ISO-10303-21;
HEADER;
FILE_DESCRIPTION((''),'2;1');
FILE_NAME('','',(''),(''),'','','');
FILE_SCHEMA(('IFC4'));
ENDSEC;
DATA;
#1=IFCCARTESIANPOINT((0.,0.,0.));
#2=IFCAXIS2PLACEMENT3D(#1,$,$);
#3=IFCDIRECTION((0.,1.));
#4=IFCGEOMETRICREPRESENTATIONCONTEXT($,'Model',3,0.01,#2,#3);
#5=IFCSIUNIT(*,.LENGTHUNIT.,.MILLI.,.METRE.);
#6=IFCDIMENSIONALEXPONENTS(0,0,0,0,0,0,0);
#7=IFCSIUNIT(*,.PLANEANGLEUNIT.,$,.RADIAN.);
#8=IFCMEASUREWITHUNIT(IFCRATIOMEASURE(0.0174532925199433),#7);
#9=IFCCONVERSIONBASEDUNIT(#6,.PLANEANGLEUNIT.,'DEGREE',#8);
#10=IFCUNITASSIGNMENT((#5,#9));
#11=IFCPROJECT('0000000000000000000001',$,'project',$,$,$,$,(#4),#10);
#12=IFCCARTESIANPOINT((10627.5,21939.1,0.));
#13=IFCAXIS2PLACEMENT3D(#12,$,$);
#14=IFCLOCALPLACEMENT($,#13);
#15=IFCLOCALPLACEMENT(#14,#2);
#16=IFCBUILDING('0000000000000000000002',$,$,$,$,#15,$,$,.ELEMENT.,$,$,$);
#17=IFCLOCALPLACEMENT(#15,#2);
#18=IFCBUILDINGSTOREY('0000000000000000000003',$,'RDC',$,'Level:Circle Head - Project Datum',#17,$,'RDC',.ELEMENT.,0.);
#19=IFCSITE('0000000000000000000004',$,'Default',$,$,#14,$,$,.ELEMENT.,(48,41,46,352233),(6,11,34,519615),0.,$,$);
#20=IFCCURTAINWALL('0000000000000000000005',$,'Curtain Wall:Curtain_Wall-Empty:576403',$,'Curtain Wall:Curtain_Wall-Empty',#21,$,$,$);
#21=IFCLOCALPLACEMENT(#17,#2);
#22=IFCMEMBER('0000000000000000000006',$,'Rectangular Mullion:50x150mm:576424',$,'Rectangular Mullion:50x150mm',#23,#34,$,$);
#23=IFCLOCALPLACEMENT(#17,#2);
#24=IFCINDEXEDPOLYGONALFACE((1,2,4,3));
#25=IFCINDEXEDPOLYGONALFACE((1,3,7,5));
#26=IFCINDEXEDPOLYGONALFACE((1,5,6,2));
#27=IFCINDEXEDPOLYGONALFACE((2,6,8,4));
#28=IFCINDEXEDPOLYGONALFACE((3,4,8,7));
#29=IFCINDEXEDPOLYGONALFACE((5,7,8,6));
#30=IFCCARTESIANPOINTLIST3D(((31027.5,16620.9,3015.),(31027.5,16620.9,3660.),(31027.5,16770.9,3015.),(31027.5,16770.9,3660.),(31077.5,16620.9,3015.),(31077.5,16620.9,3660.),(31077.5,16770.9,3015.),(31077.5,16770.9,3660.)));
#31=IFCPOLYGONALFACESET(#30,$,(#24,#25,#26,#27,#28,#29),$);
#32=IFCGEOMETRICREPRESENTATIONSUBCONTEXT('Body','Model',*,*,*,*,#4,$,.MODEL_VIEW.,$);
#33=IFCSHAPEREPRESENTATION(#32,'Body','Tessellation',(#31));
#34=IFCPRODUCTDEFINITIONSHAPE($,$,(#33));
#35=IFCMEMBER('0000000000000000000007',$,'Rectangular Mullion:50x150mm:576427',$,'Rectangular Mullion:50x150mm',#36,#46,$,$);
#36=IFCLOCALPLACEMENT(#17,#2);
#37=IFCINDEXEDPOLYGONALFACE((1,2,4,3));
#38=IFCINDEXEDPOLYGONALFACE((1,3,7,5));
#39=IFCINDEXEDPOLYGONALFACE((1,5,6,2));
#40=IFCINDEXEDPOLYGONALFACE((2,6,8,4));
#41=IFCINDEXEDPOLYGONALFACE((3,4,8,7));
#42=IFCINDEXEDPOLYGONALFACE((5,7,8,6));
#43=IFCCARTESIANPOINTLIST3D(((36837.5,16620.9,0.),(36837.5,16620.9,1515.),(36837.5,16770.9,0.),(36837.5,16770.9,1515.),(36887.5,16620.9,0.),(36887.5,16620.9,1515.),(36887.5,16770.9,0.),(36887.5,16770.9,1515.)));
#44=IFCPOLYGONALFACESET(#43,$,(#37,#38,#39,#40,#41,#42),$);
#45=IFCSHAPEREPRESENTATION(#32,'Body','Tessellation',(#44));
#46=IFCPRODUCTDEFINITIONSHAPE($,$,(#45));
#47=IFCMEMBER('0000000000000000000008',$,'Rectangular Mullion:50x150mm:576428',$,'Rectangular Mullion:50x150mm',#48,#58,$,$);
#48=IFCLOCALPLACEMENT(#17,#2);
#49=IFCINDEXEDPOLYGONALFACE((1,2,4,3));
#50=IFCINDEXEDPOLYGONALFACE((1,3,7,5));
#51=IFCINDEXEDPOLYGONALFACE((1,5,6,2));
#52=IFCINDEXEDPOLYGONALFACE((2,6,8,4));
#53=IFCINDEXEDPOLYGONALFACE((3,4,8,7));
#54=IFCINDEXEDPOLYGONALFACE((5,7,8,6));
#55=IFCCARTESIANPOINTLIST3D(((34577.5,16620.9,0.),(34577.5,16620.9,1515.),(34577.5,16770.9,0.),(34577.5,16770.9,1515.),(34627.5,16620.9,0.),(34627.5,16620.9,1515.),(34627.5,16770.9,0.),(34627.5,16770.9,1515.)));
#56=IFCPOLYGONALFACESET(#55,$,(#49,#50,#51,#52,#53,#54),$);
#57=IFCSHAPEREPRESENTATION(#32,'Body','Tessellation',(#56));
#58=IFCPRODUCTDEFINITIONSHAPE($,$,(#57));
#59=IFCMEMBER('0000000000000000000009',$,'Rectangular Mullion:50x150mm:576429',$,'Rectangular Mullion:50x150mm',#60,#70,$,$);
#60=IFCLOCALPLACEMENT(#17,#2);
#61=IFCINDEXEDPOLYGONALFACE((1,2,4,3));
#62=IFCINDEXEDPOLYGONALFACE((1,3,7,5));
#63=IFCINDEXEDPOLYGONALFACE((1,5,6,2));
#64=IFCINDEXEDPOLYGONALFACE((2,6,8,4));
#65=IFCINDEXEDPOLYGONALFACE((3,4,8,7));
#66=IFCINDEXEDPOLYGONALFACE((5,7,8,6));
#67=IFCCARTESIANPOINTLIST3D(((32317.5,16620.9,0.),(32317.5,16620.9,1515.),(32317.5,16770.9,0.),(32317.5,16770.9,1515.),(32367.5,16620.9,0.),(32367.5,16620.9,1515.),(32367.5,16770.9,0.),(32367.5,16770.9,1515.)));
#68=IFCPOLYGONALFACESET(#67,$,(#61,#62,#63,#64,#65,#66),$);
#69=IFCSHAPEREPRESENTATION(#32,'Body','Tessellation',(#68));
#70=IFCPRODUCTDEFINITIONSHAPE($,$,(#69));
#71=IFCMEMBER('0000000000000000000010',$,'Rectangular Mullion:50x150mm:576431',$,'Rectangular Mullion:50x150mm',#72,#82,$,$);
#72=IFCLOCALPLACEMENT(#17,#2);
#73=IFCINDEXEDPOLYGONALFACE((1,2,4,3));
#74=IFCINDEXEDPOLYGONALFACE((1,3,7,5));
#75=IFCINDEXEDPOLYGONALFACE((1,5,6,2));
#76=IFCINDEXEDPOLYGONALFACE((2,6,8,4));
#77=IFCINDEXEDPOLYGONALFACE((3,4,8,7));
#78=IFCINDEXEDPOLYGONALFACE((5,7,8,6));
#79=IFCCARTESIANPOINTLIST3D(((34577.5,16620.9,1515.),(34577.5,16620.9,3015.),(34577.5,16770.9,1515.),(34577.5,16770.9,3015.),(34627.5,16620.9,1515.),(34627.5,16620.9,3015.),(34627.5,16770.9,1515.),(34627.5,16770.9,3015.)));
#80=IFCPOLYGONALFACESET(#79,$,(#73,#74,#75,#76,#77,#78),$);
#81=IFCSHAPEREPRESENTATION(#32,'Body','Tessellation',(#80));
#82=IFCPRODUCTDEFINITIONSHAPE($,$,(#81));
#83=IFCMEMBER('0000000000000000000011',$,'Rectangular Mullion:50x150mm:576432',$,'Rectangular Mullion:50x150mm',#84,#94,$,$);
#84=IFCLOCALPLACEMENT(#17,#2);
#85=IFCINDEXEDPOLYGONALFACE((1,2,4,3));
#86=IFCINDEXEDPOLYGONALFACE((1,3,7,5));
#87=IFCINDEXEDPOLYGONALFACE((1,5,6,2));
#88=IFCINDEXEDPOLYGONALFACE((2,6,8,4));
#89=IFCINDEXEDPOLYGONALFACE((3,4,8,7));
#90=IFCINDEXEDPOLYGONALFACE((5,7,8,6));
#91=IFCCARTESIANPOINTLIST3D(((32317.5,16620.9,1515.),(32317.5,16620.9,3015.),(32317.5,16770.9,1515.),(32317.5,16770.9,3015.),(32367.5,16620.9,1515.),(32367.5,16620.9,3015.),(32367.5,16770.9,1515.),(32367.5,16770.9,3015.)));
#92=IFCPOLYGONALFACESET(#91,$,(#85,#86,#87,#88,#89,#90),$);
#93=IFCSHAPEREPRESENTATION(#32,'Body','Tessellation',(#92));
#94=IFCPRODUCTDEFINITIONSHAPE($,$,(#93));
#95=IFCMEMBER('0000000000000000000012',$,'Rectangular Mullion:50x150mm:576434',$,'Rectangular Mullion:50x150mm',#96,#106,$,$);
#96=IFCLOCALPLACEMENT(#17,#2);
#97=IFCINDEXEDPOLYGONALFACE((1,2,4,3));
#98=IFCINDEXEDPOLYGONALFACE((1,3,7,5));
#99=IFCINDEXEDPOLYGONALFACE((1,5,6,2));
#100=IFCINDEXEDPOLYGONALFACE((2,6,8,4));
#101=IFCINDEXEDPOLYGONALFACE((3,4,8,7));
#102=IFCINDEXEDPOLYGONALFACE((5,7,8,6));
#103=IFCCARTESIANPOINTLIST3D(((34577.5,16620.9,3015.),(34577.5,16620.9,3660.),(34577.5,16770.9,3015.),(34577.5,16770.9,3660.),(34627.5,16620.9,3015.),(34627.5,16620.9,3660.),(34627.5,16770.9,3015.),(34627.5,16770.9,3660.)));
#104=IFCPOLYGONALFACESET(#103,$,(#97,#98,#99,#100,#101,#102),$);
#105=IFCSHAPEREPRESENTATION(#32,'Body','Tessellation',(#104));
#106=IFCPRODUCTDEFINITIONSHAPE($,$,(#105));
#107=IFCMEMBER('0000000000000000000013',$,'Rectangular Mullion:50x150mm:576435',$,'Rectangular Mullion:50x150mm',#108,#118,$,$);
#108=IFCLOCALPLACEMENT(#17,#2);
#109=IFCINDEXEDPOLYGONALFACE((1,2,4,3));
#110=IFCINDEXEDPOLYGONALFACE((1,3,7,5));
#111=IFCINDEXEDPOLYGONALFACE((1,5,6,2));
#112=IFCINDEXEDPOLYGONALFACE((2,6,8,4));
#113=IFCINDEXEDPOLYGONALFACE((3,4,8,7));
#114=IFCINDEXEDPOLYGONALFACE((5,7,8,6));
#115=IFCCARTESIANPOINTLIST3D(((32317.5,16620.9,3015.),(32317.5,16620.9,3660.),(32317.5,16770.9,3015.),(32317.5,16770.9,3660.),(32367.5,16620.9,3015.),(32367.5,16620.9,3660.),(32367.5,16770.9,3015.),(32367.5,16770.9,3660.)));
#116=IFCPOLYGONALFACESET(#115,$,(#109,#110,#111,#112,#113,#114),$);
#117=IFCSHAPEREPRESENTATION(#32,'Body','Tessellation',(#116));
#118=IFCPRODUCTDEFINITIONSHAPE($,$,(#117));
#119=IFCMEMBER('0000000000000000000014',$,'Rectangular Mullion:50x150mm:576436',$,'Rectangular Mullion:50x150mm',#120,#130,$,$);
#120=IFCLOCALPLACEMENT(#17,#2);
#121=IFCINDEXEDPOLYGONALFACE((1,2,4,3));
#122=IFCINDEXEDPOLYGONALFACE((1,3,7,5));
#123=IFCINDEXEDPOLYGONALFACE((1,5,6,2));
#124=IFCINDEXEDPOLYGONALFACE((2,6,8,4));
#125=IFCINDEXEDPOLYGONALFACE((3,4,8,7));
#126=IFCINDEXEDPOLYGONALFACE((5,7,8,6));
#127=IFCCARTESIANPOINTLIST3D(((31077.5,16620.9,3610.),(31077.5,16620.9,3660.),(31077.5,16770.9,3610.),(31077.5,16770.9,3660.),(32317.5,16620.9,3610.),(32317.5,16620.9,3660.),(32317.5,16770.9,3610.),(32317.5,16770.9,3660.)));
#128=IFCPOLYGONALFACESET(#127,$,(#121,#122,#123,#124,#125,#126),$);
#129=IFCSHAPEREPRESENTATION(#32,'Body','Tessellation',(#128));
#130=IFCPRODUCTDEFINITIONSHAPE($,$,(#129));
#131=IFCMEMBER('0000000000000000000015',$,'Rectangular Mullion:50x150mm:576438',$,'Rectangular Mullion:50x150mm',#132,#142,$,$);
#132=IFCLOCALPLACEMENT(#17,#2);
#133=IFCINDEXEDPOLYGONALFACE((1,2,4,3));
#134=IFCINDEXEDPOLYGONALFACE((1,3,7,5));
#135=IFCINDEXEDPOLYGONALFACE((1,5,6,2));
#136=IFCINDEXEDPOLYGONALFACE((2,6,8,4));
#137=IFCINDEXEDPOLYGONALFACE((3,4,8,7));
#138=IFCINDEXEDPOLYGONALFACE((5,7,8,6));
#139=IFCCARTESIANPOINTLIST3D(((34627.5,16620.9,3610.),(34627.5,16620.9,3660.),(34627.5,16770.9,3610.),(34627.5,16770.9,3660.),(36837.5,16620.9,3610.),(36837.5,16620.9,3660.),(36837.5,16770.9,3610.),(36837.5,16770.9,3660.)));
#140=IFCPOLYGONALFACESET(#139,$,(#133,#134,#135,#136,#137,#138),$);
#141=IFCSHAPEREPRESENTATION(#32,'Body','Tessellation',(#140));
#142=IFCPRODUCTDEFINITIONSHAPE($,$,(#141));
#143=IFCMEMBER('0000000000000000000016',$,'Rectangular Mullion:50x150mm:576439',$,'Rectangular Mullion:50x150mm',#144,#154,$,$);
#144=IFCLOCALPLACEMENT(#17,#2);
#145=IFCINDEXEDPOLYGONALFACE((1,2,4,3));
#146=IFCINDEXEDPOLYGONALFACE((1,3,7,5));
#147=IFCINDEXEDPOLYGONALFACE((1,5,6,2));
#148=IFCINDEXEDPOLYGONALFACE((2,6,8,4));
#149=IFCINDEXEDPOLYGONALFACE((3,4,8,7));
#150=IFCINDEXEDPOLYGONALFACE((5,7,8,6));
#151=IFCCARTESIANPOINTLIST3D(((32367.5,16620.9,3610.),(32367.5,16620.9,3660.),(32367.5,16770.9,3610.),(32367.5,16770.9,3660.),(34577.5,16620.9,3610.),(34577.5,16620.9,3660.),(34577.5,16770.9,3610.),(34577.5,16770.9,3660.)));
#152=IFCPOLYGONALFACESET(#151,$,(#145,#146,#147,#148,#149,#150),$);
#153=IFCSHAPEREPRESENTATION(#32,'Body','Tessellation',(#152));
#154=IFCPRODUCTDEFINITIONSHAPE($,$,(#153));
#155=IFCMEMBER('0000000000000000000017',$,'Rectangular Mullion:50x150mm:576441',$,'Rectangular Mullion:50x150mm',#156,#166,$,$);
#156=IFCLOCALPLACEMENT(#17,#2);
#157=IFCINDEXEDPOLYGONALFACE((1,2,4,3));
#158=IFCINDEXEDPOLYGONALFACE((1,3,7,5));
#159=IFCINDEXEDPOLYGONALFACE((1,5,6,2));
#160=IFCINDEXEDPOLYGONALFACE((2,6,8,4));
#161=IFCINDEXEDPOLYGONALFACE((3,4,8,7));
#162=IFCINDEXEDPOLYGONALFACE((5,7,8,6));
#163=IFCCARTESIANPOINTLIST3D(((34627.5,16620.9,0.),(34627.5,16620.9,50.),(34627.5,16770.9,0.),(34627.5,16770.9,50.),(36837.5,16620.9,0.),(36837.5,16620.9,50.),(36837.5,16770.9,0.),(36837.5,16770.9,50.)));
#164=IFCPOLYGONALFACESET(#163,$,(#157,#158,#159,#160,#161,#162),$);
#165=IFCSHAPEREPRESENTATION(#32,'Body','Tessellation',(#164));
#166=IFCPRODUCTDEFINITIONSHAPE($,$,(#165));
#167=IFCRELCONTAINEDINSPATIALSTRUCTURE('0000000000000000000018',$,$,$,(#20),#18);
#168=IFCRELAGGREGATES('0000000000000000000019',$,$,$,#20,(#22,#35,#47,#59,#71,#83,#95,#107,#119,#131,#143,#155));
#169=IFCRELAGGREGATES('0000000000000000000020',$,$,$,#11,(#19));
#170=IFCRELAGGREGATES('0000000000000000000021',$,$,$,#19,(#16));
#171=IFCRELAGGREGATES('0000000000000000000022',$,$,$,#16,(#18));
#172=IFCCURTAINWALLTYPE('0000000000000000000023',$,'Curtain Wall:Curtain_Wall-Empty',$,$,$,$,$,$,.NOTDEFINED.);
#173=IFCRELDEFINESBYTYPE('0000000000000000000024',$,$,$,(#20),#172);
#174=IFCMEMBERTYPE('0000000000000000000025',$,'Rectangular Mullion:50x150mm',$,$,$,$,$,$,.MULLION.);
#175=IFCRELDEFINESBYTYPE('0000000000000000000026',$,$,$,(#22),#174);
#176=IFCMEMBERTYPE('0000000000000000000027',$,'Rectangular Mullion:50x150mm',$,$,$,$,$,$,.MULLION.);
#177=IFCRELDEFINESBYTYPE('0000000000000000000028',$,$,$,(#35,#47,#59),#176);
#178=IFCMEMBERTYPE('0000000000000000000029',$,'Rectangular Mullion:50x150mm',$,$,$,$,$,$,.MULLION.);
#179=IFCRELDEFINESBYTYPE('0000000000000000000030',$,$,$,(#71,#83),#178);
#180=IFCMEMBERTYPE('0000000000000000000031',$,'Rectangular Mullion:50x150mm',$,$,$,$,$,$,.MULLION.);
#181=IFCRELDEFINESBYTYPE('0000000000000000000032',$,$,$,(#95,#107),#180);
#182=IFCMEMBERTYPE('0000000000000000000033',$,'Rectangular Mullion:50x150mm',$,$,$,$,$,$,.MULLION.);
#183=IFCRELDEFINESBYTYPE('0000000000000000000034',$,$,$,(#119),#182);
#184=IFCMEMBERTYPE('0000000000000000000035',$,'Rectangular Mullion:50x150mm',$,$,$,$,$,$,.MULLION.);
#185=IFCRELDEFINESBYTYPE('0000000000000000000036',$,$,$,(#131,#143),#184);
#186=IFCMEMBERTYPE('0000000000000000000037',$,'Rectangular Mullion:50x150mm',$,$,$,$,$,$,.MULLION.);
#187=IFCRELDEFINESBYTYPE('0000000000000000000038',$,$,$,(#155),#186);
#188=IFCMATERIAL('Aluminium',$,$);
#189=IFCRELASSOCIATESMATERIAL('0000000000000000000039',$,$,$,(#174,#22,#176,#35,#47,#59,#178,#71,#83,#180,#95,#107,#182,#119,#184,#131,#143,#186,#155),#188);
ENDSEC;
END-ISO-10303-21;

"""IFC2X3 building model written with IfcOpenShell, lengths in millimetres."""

from ifc_helpers import new_model, entity, si_unit, converted_unit, direction, frame, origin, origin_2d_with_axis, place, context, subcontext, project, spatial, rectangle, extrude, source, transform, mapped, material, type_object, type_shapes, element, aggregate, save


model = new_model("IFC2X3")

# Units and contexts
model_context = context("Model", 3, precision=0.01, world=origin(), true_north=direction((0.0, 1.0)))
body_context = subcontext(model_context, "Body", "Model", "MODEL_VIEW")
ifc_project = project(units=[si_unit("LENGTHUNIT", "METRE", prefix="MILLI"), converted_unit("PLANEANGLEUNIT", "DEGREE", entity("IfcRatioMeasure", 0.0174532925199433), si_unit("PLANEANGLEUNIT", "RADIAN"), dimensions=[0, 0, 0, 0, 0, 0, 0])], contexts=[model_context])

# Site, building, storey
site_placement = place(None, frame((10627.5, 21939.1, 0.0)))
site = spatial("IfcSite", under=ifc_project, at=site_placement, Name="Default", CompositionType="ELEMENT", RefLatitude=(48, 41, 46, 352233), RefLongitude=(6, 11, 34, 519615), RefElevation=0.0)
building_placement = place(site_placement, origin())
building = spatial("IfcBuilding", under=site, at=building_placement, CompositionType="ELEMENT")
storey_placement = place(building_placement, origin())
storey = spatial("IfcBuildingStorey", under=building, at=storey_placement, Name="RDC", ObjectType="Level:Circle Head - Project Datum", LongName="RDC", CompositionType="ELEMENT", Elevation=0.0)

# Curtain wall, members
curtain_wall_type = type_object("IfcCurtainWallType", Name="Curtain Wall:Curtain_Wall-Empty", PredefinedType="NOTDEFINED")
curtain_wall_placement = place(storey_placement, origin())
curtain_wall = element("IfcCurtainWall", 1, at=curtain_wall_placement, inside=storey, type_object=curtain_wall_type, Name="Curtain Wall:Curtain_Wall-Empty:576403", ObjectType="Curtain Wall:Curtain_Wall-Empty")
ifc_material_1 = material(Name="Aluminium")
member_type_1 = type_object("IfcMemberType", Name="Rectangular Mullion:50x150mm", PredefinedType="MULLION", material=ifc_material_1)
shared_shape_1 = source(origin(), body_context, "Body", "SweptSolid", [
    extrude(rectangle(XDim=150.0, YDim=50.0, at=origin_2d_with_axis()), frame((-25.0, 0.0, -645.0), z_axis=(0.0, 0.0, 1.0), x_axis=(0.0, -1.0, 0.0)), (0.0, 0.0, 1.0), 645.0),
])
type_shapes(member_type_1, [shared_shape_1])
member_1_placement = place(storey_placement, frame((31027.5, 16695.9, 3015.0), z_axis=(0.0, 0.0, -1.0), x_axis=(-1.0, 0.0, 0.0)))
member_1 = element("IfcMember", 2, at=member_1_placement, type_object=member_type_1, material=ifc_material_1, Name="Rectangular Mullion:50x150mm:576424", ObjectType="Rectangular Mullion:50x150mm", context=body_context, shape_type="MappedRepresentation", body=[
    mapped(shared_shape_1, transform((0.0, 0.0, 0.0), scale=1.0)),
])
member_type_2 = type_object("IfcMemberType", Name="Rectangular Mullion:50x150mm", PredefinedType="MULLION", material=ifc_material_1)
shared_shape_2 = source(origin(), body_context, "Body", "SweptSolid", [
    extrude(rectangle(XDim=150.0, YDim=50.0, at=origin_2d_with_axis()), frame((0.0, 0.0, -1515.0), z_axis=(0.0, 0.0, 1.0), x_axis=(0.0, -1.0, 0.0)), (0.0, 0.0, 1.0), 1515.0),
])
type_shapes(member_type_2, [shared_shape_2])
member_2_placement = place(storey_placement, frame((36862.5, 16695.9, 0.0), z_axis=(0.0, 0.0, -1.0), x_axis=(-1.0, 0.0, 0.0)))
member_2 = element("IfcMember", 3, at=member_2_placement, type_object=member_type_2, material=ifc_material_1, Name="Rectangular Mullion:50x150mm:576427", ObjectType="Rectangular Mullion:50x150mm", context=body_context, shape_type="MappedRepresentation", body=[
    mapped(shared_shape_2, transform((0.0, 0.0, 0.0), scale=1.0)),
])
member_3_placement = place(storey_placement, frame((34602.5, 16695.9, 0.0), z_axis=(0.0, 0.0, -1.0), x_axis=(-1.0, 0.0, 0.0)))
member_3 = element("IfcMember", 4, at=member_3_placement, type_object=member_type_2, material=ifc_material_1, Name="Rectangular Mullion:50x150mm:576428", ObjectType="Rectangular Mullion:50x150mm", context=body_context, shape_type="MappedRepresentation", body=[
    mapped(shared_shape_2, transform((0.0, 0.0, 0.0), scale=1.0)),
])
member_4_placement = place(storey_placement, frame((32342.5, 16695.9, 0.0), z_axis=(0.0, 0.0, -1.0), x_axis=(-1.0, 0.0, 0.0)))
member_4 = element("IfcMember", 5, at=member_4_placement, type_object=member_type_2, material=ifc_material_1, Name="Rectangular Mullion:50x150mm:576429", ObjectType="Rectangular Mullion:50x150mm", context=body_context, shape_type="MappedRepresentation", body=[
    mapped(shared_shape_2, transform((0.0, 0.0, 0.0), scale=1.0)),
])
member_type_3 = type_object("IfcMemberType", Name="Rectangular Mullion:50x150mm", PredefinedType="MULLION", material=ifc_material_1)
shared_shape_3 = source(origin(), body_context, "Body", "SweptSolid", [
    extrude(rectangle(XDim=150.0, YDim=50.0, at=origin_2d_with_axis()), frame((0.0, 0.0, -1500.0), z_axis=(0.0, 0.0, 1.0), x_axis=(0.0, -1.0, 0.0)), (0.0, 0.0, 1.0), 1500.0),
])
type_shapes(member_type_3, [shared_shape_3])
member_5_placement = place(storey_placement, frame((34602.5, 16695.9, 1515.0), z_axis=(0.0, 0.0, -1.0), x_axis=(-1.0, 0.0, 0.0)))
member_5 = element("IfcMember", 6, at=member_5_placement, type_object=member_type_3, material=ifc_material_1, Name="Rectangular Mullion:50x150mm:576431", ObjectType="Rectangular Mullion:50x150mm", context=body_context, shape_type="MappedRepresentation", body=[
    mapped(shared_shape_3, transform((0.0, 0.0, 0.0), scale=1.0)),
])
member_6_placement = place(storey_placement, frame((32342.5, 16695.9, 1515.0), z_axis=(0.0, 0.0, -1.0), x_axis=(-1.0, 0.0, 0.0)))
member_6 = element("IfcMember", 7, at=member_6_placement, type_object=member_type_3, material=ifc_material_1, Name="Rectangular Mullion:50x150mm:576432", ObjectType="Rectangular Mullion:50x150mm", context=body_context, shape_type="MappedRepresentation", body=[
    mapped(shared_shape_3, transform((0.0, 0.0, 0.0), scale=1.0)),
])
member_type_4 = type_object("IfcMemberType", Name="Rectangular Mullion:50x150mm", PredefinedType="MULLION", material=ifc_material_1)
shared_shape_4 = source(origin(), body_context, "Body", "SweptSolid", [
    extrude(rectangle(XDim=150.0, YDim=50.0, at=origin_2d_with_axis()), frame((0.0, 0.0, -645.0), z_axis=(0.0, 0.0, 1.0), x_axis=(0.0, -1.0, 0.0)), (0.0, 0.0, 1.0), 645.0),
])
type_shapes(member_type_4, [shared_shape_4])
member_7_placement = place(storey_placement, frame((34602.5, 16695.9, 3015.0), z_axis=(0.0, 0.0, -1.0), x_axis=(-1.0, 0.0, 0.0)))
member_7 = element("IfcMember", 8, at=member_7_placement, type_object=member_type_4, material=ifc_material_1, Name="Rectangular Mullion:50x150mm:576434", ObjectType="Rectangular Mullion:50x150mm", context=body_context, shape_type="MappedRepresentation", body=[
    mapped(shared_shape_4, transform((0.0, 0.0, 0.0), scale=1.0)),
])
member_8_placement = place(storey_placement, frame((32342.5, 16695.9, 3015.0), z_axis=(0.0, 0.0, -1.0), x_axis=(-1.0, 0.0, 0.0)))
member_8 = element("IfcMember", 9, at=member_8_placement, type_object=member_type_4, material=ifc_material_1, Name="Rectangular Mullion:50x150mm:576435", ObjectType="Rectangular Mullion:50x150mm", context=body_context, shape_type="MappedRepresentation", body=[
    mapped(shared_shape_4, transform((0.0, 0.0, 0.0), scale=1.0)),
])
member_type_5 = type_object("IfcMemberType", Name="Rectangular Mullion:50x150mm", PredefinedType="MULLION", material=ifc_material_1)
shared_shape_5 = source(origin(), body_context, "Body", "SweptSolid", [
    extrude(rectangle(XDim=150.0, YDim=50.0, at=origin_2d_with_axis()), frame((-25.0, 0.0, -1240.0), z_axis=(0.0, 0.0, 1.0), x_axis=(0.0, -1.0, 0.0)), (0.0, 0.0, 1.0), 1240.0),
])
type_shapes(member_type_5, [shared_shape_5])
member_9_placement = place(storey_placement, frame((31077.5, 16695.9, 3660.0), z_axis=(-1.0, 0.0, 0.0), x_axis=(0.0, 0.0, 1.0)))
member_9 = element("IfcMember", 10, at=member_9_placement, type_object=member_type_5, material=ifc_material_1, Name="Rectangular Mullion:50x150mm:576436", ObjectType="Rectangular Mullion:50x150mm", context=body_context, shape_type="MappedRepresentation", body=[
    mapped(shared_shape_5, transform((0.0, 0.0, 0.0), scale=1.0)),
])
member_type_6 = type_object("IfcMemberType", Name="Rectangular Mullion:50x150mm", PredefinedType="MULLION", material=ifc_material_1)
shared_shape_6 = source(origin(), body_context, "Body", "SweptSolid", [
    extrude(rectangle(XDim=150.0, YDim=50.0, at=origin_2d_with_axis()), frame((-25.0, 0.0, -2210.0), z_axis=(0.0, 0.0, 1.0), x_axis=(0.0, -1.0, 0.0)), (0.0, 0.0, 1.0), 2210.0),
])
type_shapes(member_type_6, [shared_shape_6])
member_10_placement = place(storey_placement, frame((34627.5, 16695.9, 3660.0), z_axis=(-1.0, 0.0, 0.0), x_axis=(0.0, 0.0, 1.0)))
member_10 = element("IfcMember", 11, at=member_10_placement, type_object=member_type_6, material=ifc_material_1, Name="Rectangular Mullion:50x150mm:576438", ObjectType="Rectangular Mullion:50x150mm", context=body_context, shape_type="MappedRepresentation", body=[
    mapped(shared_shape_6, transform((0.0, 0.0, 0.0), scale=1.0)),
])
member_11_placement = place(storey_placement, frame((32367.5, 16695.9, 3660.0), z_axis=(-1.0, 0.0, 0.0), x_axis=(0.0, 0.0, 1.0)))
member_11 = element("IfcMember", 12, at=member_11_placement, type_object=member_type_6, material=ifc_material_1, Name="Rectangular Mullion:50x150mm:576439", ObjectType="Rectangular Mullion:50x150mm", context=body_context, shape_type="MappedRepresentation", body=[
    mapped(shared_shape_6, transform((0.0, 0.0, 0.0), scale=1.0)),
])
member_type_7 = type_object("IfcMemberType", Name="Rectangular Mullion:50x150mm", PredefinedType="MULLION", material=ifc_material_1)
shared_shape_7 = source(origin(), body_context, "Body", "SweptSolid", [
    extrude(rectangle(XDim=150.0, YDim=50.0, at=origin_2d_with_axis()), frame((-25.0, 0.0, -2210.0), z_axis=(0.0, 0.0, 1.0), x_axis=(0.0, -1.0, 0.0)), (0.0, 0.0, 1.0), 2210.0),
])
type_shapes(member_type_7, [shared_shape_7])
member_12_placement = place(storey_placement, frame((36837.5, 16695.9, 0.0), z_axis=(1.0, 0.0, 0.0), x_axis=(0.0, 0.0, -1.0)))
member_12 = element("IfcMember", 13, at=member_12_placement, type_object=member_type_7, material=ifc_material_1, Name="Rectangular Mullion:50x150mm:576441", ObjectType="Rectangular Mullion:50x150mm", context=body_context, shape_type="MappedRepresentation", body=[
    mapped(shared_shape_7, transform((0.0, 0.0, 0.0), scale=1.0)),
])
aggregate(curtain_wall, [member_1, member_2, member_3, member_4, member_5, member_6, member_7, member_8, member_9, member_10, member_11, member_12])

save(model, "model.ifc")
